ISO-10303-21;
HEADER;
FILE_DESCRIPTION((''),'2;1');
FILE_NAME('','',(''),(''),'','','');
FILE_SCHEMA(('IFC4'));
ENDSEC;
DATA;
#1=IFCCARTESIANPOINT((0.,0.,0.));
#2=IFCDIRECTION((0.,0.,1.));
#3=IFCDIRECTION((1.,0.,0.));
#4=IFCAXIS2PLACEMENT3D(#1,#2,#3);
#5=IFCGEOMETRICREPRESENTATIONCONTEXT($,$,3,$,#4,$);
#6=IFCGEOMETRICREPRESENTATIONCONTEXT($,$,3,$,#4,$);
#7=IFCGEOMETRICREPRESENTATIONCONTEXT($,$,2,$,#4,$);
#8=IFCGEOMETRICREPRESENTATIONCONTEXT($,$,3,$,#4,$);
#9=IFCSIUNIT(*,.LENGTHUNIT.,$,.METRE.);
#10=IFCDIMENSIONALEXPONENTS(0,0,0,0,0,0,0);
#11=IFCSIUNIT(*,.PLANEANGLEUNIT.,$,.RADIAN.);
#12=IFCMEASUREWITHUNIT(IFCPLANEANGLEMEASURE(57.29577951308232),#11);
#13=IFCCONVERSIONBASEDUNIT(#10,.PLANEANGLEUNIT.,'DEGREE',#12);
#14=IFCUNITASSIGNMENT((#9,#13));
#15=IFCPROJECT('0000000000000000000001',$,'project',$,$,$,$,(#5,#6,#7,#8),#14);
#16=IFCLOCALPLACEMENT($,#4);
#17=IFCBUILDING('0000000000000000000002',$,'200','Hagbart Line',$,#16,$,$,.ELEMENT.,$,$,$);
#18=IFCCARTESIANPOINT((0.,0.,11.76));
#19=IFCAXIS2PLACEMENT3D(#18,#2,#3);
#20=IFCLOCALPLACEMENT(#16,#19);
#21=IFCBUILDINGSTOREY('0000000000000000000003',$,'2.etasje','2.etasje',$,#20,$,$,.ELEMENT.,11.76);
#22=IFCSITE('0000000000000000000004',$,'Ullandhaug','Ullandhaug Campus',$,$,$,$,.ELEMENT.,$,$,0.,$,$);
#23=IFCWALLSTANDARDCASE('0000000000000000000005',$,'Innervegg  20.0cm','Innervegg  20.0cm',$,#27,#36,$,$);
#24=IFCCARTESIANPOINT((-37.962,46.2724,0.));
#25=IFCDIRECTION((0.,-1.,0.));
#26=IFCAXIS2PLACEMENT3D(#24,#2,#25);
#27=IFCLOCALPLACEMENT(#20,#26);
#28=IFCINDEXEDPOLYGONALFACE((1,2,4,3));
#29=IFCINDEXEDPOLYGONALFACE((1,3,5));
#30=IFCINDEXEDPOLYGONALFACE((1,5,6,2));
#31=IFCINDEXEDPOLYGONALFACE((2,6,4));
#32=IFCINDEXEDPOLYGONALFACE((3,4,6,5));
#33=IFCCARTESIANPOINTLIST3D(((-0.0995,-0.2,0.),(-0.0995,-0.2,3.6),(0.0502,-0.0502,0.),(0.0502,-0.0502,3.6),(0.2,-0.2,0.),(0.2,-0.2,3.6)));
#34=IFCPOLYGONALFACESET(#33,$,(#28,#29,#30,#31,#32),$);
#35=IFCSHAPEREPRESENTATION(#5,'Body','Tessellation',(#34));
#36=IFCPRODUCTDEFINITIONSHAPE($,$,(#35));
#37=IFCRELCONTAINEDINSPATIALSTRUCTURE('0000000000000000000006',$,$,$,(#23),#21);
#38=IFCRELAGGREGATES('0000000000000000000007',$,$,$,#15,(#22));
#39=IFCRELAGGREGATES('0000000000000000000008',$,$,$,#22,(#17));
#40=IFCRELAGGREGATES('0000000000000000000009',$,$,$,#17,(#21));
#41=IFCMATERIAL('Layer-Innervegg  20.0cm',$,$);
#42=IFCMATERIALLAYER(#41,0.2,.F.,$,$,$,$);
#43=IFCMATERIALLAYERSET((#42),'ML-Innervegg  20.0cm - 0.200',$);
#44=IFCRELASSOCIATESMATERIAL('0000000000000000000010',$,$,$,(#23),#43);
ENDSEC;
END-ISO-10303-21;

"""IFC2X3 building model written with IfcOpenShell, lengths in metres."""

from ifc_helpers import new_model, entity, si_unit, converted_unit, frame, origin_with_axes, place, context, project, spatial, polyline, outline, extrude, material, layer, layer_set, layer_usage, element, save


model = new_model("IFC2X3")

# Units and contexts
context_of_model_1 = context(None, 3, world=origin_with_axes())
context_of_model_2 = context(None, 3, world=origin_with_axes())
context_of_model_3 = context(None, 2, world=origin_with_axes())
context_of_model_4 = context(None, 3, world=origin_with_axes())
ifc_project = project(units=[si_unit("LENGTHUNIT", "METRE"), converted_unit("PLANEANGLEUNIT", "DEGREE", entity("IfcPlaneAngleMeasure", 57.29577951308232), si_unit("PLANEANGLEUNIT", "RADIAN"), dimensions=[0, 0, 0, 0, 0, 0, 0])], contexts=[context_of_model_1, context_of_model_2, context_of_model_3, context_of_model_4])

# Site, building, storey
site = spatial("IfcSite", under=ifc_project, Name="Ullandhaug", Description="Ullandhaug Campus", CompositionType="ELEMENT", RefElevation=0.0)
building_placement = place(None, origin_with_axes())
building = spatial("IfcBuilding", under=site, at=building_placement, Name="200", Description="Hagbart Line", CompositionType="ELEMENT")
storey_placement = place(building_placement, frame((0.0, 0.0, 11.76), z_axis=(0.0, 0.0, 1.0), x_axis=(1.0, 0.0, 0.0)))
storey = spatial("IfcBuildingStorey", under=building, at=storey_placement, Name="2.etasje", Description="2.etasje", CompositionType="ELEMENT", Elevation=11.76)

# Wall
ifc_material_1 = material(Name="Layer-Innervegg  20.0cm")
ifc_layer_1 = layer(ifc_material_1, 0.2, ventilated=False)
ifc_layer_set_1 = layer_set([ifc_layer_1], Name="ML-Innervegg  20.0cm - 0.200")
ifc_layer_usage_1 = layer_usage(ifc_layer_set_1, "AXIS2", "POSITIVE", 0.0)
wall_1_placement = place(storey_placement, frame((-37.962, 46.2724, 0.0), z_axis=(0.0, 0.0, 1.0), x_axis=(0.0, -1.0, 0.0)))
element("IfcWallStandardCase", 1, at=wall_1_placement, inside=storey, material=ifc_layer_usage_1, Name="Innervegg  20.0cm", Description="Innervegg  20.0cm", context=context_of_model_1, shape_type="SweptSolid", body=[
    extrude(outline(polyline([(0.0, 0.0), (0.1005, 0.0), (-0.0995, 0.2), (0.2, 0.2), (0.0, 0.0)])), frame((0.0, 0.0, 0.0), z_axis=(0.0, 0.0, -1.0), x_axis=(1.0, 0.0, 0.0)), (0.0, 0.0, -1.0), 3.6),
])

save(model, "model.ifc")
